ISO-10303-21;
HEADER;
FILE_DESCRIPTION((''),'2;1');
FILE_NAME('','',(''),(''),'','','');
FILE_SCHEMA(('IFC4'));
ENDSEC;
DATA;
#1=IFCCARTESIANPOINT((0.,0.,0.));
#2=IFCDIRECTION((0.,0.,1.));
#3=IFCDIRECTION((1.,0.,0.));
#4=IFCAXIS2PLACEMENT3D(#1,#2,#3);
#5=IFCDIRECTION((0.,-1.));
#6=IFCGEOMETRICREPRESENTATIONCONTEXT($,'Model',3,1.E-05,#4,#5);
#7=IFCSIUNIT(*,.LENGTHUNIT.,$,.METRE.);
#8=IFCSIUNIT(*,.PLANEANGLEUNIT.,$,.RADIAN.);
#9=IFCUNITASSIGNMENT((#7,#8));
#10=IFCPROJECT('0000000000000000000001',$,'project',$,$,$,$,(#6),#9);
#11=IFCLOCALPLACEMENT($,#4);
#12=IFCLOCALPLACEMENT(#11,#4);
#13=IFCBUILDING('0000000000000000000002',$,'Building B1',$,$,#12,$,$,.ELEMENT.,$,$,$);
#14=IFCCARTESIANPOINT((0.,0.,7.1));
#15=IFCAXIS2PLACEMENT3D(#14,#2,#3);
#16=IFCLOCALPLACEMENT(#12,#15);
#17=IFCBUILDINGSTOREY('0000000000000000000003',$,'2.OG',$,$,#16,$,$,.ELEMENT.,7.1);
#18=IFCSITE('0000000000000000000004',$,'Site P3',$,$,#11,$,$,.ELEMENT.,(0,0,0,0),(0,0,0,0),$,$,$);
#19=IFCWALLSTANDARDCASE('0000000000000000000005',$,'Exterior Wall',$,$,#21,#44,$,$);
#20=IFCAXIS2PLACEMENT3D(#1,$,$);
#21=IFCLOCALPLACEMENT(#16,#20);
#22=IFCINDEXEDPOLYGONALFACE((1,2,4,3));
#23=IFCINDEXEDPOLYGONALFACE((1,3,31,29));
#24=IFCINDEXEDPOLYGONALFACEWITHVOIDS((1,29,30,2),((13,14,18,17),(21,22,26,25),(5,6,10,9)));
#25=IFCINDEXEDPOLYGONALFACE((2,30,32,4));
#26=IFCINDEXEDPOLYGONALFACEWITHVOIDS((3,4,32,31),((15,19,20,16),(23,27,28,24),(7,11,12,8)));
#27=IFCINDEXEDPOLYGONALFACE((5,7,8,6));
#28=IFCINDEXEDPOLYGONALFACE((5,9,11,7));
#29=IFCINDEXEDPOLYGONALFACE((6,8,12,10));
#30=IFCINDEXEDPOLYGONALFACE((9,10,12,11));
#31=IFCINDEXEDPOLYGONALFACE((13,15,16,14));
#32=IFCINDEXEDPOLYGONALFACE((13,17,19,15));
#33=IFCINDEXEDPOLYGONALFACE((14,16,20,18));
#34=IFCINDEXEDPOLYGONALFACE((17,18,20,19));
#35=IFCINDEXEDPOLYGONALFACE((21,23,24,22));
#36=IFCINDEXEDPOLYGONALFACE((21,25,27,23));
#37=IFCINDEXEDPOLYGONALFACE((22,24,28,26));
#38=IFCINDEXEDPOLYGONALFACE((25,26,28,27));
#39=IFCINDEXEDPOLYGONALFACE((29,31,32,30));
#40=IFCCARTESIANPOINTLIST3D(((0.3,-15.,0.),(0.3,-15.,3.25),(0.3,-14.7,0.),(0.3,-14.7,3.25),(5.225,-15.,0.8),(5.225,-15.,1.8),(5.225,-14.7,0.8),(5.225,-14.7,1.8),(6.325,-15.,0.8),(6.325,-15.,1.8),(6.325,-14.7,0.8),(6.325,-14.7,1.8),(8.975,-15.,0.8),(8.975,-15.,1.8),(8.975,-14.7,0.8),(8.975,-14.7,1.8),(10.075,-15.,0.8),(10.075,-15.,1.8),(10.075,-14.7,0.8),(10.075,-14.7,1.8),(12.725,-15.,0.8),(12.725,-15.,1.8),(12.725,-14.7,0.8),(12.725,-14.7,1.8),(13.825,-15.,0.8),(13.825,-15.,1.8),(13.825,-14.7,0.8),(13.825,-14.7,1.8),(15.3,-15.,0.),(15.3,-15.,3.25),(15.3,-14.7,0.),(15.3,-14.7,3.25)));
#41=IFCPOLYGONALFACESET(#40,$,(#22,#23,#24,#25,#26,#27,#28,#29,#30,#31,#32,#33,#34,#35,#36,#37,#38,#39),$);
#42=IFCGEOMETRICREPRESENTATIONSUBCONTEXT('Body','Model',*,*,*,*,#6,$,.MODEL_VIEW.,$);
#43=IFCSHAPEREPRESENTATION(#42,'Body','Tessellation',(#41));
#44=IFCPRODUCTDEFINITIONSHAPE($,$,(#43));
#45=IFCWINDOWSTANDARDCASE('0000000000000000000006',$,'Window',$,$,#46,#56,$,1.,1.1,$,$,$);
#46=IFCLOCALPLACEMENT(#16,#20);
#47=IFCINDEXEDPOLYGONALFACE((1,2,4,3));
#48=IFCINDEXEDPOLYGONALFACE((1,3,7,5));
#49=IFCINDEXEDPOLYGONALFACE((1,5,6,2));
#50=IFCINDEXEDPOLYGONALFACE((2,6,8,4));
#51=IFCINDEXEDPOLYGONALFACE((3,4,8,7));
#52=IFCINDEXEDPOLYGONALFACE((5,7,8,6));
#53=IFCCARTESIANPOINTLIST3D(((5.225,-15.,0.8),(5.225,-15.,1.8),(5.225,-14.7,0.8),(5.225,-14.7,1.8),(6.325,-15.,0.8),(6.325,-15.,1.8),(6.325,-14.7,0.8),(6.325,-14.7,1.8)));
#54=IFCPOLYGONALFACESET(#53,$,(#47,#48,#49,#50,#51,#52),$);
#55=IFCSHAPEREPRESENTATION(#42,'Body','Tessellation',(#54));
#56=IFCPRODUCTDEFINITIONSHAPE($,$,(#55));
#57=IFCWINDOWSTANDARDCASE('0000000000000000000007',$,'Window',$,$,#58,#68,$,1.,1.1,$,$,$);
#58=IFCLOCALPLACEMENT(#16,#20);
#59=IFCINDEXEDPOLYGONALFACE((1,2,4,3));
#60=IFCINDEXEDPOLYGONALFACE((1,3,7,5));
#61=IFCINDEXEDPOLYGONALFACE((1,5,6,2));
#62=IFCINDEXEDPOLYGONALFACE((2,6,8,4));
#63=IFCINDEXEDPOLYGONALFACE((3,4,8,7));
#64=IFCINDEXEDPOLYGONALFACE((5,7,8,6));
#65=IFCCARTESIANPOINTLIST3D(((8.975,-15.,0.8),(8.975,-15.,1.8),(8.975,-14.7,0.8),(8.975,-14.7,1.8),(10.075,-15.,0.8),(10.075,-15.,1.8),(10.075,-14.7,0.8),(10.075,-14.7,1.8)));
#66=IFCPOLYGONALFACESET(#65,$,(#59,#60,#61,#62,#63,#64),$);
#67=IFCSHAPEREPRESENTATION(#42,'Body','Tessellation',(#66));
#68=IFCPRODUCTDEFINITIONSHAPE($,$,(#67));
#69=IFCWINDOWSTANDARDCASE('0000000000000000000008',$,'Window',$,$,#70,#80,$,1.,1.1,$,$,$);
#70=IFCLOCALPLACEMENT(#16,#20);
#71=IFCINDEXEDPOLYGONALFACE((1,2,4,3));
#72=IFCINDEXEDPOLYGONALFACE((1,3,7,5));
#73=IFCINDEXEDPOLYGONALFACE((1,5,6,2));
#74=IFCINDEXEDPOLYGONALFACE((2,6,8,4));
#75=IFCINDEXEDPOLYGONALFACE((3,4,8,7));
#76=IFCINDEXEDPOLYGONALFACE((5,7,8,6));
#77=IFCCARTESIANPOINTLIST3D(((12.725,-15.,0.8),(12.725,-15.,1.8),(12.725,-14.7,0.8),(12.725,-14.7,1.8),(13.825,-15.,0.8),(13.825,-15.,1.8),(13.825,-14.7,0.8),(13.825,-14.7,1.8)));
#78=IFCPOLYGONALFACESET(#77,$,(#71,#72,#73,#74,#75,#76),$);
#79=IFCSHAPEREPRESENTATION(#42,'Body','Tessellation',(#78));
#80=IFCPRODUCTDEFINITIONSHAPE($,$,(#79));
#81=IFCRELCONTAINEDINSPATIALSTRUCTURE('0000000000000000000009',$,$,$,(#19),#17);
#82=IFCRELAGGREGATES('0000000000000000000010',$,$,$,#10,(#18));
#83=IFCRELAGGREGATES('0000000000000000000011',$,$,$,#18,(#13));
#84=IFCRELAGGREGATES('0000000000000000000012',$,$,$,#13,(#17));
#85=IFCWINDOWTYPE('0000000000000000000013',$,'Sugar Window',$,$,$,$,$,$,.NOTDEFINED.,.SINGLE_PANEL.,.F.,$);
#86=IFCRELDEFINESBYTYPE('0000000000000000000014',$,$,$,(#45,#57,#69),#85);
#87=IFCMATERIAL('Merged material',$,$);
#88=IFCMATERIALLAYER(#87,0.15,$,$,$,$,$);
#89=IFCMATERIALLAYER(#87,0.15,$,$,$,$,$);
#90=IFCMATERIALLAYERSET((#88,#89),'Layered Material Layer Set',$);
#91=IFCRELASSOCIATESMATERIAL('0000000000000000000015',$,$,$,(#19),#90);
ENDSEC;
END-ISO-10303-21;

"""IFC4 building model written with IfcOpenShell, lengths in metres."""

from ifc_helpers import new_model, si_unit, direction, frame, origin_with_axes, place, context, subcontext, project, spatial, polyline, outline, extrude, source, transform, mapped, material, layer, layer_set, layer_usage, type_object, element, fill, save


model = new_model("IFC4")

# Units and contexts
model_context = context("Model", 3, precision=1e-05, world=origin_with_axes(), true_north=direction((0.0, -1.0)))
body_context = subcontext(model_context, "Body", "Model", "MODEL_VIEW")
ifc_project = project(units=[si_unit("LENGTHUNIT", "METRE"), si_unit("PLANEANGLEUNIT", "RADIAN")], contexts=[model_context])

# Site, building, storey
site_placement = place(None, origin_with_axes())
site = spatial("IfcSite", under=ifc_project, at=site_placement, Name="Site P3", CompositionType="ELEMENT", RefLatitude=(0, 0, 0, 0), RefLongitude=(0, 0, 0, 0))
building_placement = place(site_placement, origin_with_axes())
building = spatial("IfcBuilding", under=site, at=building_placement, Name="Building B1", CompositionType="ELEMENT")
storey_placement = place(building_placement, frame((0.0, 0.0, 7.1), z_axis=(0.0, 0.0, 1.0), x_axis=(1.0, 0.0, 0.0)))
storey = spatial("IfcBuildingStorey", under=building, at=storey_placement, Name="2.OG", CompositionType="ELEMENT", Elevation=7.1)

# Wall, openings, windows
ifc_material = material(Name="Merged material")
ifc_layer_1 = layer(ifc_material, 0.15)
ifc_layer_2 = layer(ifc_material, 0.15)
ifc_layer_set_1 = layer_set([ifc_layer_1, ifc_layer_2], Name="Layered Material Layer Set")
ifc_layer_usage_1 = layer_usage(ifc_layer_set_1, "AXIS2", "POSITIVE", -0.15)
wall_1_placement = place(storey_placement, frame((0.3, -14.85, 0.0), z_axis=(0.0, 0.0, 1.0), x_axis=(1.0, 0.0, 0.0)))
wall_1 = element("IfcWallStandardCase", 1, at=wall_1_placement, inside=storey, material=ifc_layer_usage_1, Name="Exterior Wall", context=body_context, shape_type="SweptSolid", body=[
    extrude(outline(polyline([(0.0, 0.15), (15.0, 0.15), (15.0, -0.15), (0.0, -0.15), (0.0, 0.15)])), origin_with_axes(), (0.0, 0.0, 1.0), 3.25),
])
opening_1_placement = place(wall_1_placement, frame((4.925, 0.0, 0.8), z_axis=(0.0, 0.0, 1.0), x_axis=(1.0, 0.0, 0.0)))
opening_1 = element("IfcOpeningStandardCase", 2, at=opening_1_placement, cuts=wall_1, context=body_context, shape_type="SweptSolid", body=[
    extrude(outline(polyline([(0.0, 0.0), (0.0, 1.1), (1.0, 1.1), (1.0, 0.0), (0.0, 0.0)])), frame((0.0, -0.15, 0.0), z_axis=(0.0, 1.0, 0.0), x_axis=(0.0, 0.0, 1.0)), (0.0, 0.0, 1.0), 0.3),
])
opening_2_placement = place(wall_1_placement, frame((8.675, 0.0, 0.8), z_axis=(0.0, 0.0, 1.0), x_axis=(1.0, 0.0, 0.0)))
opening_2 = element("IfcOpeningStandardCase", 3, at=opening_2_placement, cuts=wall_1, context=body_context, shape_type="SweptSolid", body=[
    extrude(outline(polyline([(0.0, 0.0), (0.0, 1.1), (1.0, 1.1), (1.0, 0.0), (0.0, 0.0)])), frame((0.0, -0.15, 0.0), z_axis=(0.0, 1.0, 0.0), x_axis=(0.0, 0.0, 1.0)), (0.0, 0.0, 1.0), 0.3),
])
opening_3_placement = place(wall_1_placement, frame((12.425, 0.0, 0.8), z_axis=(0.0, 0.0, 1.0), x_axis=(1.0, 0.0, 0.0)))
opening_3 = element("IfcOpeningStandardCase", 4, at=opening_3_placement, cuts=wall_1, context=body_context, shape_type="SweptSolid", body=[
    extrude(outline(polyline([(0.0, 0.0), (0.0, 1.1), (1.0, 1.1), (1.0, 0.0), (0.0, 0.0)])), frame((0.0, -0.15, 0.0), z_axis=(0.0, 1.0, 0.0), x_axis=(0.0, 0.0, 1.0)), (0.0, 0.0, 1.0), 0.3),
])
window_type = type_object("IfcWindowType", Name="Sugar Window", ParameterTakesPrecedence=False, PartitioningType="SINGLE_PANEL", PredefinedType="NOTDEFINED")
shared_shape_1 = source(origin_with_axes(), body_context, "Body", "SweptSolid", [
    extrude(outline(polyline([(0.0, 0.0), (0.0, 1.1), (1.0, 1.1), (1.0, 0.0), (0.0, 0.0)])), frame((0.0, -0.15, 0.0), z_axis=(0.0, 1.0, 0.0), x_axis=(0.0, 0.0, 1.0)), (0.0, 0.0, 1.0), 0.3),
])
window_1_placement = place(opening_1_placement, origin_with_axes())
window_1 = element("IfcWindowStandardCase", 5, at=window_1_placement, type_object=window_type, Name="Window", OverallHeight=1.0, OverallWidth=1.1, context=body_context, shape_type="MappedRepresentation", body=[
    mapped(shared_shape_1, transform((0.0, 0.0, 0.0))),
])
fill(opening_1, window_1)
window_2_placement = place(opening_2_placement, origin_with_axes())
window_2 = element("IfcWindowStandardCase", 6, at=window_2_placement, type_object=window_type, Name="Window", OverallHeight=1.0, OverallWidth=1.1, context=body_context, shape_type="MappedRepresentation", body=[
    mapped(shared_shape_1, transform((0.0, 0.0, 0.0))),
])
fill(opening_2, window_2)
window_3_placement = place(opening_3_placement, origin_with_axes())
window_3 = element("IfcWindowStandardCase", 7, at=window_3_placement, type_object=window_type, Name="Window", OverallHeight=1.0, OverallWidth=1.1, context=body_context, shape_type="MappedRepresentation", body=[
    mapped(shared_shape_1, transform((0.0, 0.0, 0.0))),
])
fill(opening_3, window_3)

save(model, "model.ifc")
